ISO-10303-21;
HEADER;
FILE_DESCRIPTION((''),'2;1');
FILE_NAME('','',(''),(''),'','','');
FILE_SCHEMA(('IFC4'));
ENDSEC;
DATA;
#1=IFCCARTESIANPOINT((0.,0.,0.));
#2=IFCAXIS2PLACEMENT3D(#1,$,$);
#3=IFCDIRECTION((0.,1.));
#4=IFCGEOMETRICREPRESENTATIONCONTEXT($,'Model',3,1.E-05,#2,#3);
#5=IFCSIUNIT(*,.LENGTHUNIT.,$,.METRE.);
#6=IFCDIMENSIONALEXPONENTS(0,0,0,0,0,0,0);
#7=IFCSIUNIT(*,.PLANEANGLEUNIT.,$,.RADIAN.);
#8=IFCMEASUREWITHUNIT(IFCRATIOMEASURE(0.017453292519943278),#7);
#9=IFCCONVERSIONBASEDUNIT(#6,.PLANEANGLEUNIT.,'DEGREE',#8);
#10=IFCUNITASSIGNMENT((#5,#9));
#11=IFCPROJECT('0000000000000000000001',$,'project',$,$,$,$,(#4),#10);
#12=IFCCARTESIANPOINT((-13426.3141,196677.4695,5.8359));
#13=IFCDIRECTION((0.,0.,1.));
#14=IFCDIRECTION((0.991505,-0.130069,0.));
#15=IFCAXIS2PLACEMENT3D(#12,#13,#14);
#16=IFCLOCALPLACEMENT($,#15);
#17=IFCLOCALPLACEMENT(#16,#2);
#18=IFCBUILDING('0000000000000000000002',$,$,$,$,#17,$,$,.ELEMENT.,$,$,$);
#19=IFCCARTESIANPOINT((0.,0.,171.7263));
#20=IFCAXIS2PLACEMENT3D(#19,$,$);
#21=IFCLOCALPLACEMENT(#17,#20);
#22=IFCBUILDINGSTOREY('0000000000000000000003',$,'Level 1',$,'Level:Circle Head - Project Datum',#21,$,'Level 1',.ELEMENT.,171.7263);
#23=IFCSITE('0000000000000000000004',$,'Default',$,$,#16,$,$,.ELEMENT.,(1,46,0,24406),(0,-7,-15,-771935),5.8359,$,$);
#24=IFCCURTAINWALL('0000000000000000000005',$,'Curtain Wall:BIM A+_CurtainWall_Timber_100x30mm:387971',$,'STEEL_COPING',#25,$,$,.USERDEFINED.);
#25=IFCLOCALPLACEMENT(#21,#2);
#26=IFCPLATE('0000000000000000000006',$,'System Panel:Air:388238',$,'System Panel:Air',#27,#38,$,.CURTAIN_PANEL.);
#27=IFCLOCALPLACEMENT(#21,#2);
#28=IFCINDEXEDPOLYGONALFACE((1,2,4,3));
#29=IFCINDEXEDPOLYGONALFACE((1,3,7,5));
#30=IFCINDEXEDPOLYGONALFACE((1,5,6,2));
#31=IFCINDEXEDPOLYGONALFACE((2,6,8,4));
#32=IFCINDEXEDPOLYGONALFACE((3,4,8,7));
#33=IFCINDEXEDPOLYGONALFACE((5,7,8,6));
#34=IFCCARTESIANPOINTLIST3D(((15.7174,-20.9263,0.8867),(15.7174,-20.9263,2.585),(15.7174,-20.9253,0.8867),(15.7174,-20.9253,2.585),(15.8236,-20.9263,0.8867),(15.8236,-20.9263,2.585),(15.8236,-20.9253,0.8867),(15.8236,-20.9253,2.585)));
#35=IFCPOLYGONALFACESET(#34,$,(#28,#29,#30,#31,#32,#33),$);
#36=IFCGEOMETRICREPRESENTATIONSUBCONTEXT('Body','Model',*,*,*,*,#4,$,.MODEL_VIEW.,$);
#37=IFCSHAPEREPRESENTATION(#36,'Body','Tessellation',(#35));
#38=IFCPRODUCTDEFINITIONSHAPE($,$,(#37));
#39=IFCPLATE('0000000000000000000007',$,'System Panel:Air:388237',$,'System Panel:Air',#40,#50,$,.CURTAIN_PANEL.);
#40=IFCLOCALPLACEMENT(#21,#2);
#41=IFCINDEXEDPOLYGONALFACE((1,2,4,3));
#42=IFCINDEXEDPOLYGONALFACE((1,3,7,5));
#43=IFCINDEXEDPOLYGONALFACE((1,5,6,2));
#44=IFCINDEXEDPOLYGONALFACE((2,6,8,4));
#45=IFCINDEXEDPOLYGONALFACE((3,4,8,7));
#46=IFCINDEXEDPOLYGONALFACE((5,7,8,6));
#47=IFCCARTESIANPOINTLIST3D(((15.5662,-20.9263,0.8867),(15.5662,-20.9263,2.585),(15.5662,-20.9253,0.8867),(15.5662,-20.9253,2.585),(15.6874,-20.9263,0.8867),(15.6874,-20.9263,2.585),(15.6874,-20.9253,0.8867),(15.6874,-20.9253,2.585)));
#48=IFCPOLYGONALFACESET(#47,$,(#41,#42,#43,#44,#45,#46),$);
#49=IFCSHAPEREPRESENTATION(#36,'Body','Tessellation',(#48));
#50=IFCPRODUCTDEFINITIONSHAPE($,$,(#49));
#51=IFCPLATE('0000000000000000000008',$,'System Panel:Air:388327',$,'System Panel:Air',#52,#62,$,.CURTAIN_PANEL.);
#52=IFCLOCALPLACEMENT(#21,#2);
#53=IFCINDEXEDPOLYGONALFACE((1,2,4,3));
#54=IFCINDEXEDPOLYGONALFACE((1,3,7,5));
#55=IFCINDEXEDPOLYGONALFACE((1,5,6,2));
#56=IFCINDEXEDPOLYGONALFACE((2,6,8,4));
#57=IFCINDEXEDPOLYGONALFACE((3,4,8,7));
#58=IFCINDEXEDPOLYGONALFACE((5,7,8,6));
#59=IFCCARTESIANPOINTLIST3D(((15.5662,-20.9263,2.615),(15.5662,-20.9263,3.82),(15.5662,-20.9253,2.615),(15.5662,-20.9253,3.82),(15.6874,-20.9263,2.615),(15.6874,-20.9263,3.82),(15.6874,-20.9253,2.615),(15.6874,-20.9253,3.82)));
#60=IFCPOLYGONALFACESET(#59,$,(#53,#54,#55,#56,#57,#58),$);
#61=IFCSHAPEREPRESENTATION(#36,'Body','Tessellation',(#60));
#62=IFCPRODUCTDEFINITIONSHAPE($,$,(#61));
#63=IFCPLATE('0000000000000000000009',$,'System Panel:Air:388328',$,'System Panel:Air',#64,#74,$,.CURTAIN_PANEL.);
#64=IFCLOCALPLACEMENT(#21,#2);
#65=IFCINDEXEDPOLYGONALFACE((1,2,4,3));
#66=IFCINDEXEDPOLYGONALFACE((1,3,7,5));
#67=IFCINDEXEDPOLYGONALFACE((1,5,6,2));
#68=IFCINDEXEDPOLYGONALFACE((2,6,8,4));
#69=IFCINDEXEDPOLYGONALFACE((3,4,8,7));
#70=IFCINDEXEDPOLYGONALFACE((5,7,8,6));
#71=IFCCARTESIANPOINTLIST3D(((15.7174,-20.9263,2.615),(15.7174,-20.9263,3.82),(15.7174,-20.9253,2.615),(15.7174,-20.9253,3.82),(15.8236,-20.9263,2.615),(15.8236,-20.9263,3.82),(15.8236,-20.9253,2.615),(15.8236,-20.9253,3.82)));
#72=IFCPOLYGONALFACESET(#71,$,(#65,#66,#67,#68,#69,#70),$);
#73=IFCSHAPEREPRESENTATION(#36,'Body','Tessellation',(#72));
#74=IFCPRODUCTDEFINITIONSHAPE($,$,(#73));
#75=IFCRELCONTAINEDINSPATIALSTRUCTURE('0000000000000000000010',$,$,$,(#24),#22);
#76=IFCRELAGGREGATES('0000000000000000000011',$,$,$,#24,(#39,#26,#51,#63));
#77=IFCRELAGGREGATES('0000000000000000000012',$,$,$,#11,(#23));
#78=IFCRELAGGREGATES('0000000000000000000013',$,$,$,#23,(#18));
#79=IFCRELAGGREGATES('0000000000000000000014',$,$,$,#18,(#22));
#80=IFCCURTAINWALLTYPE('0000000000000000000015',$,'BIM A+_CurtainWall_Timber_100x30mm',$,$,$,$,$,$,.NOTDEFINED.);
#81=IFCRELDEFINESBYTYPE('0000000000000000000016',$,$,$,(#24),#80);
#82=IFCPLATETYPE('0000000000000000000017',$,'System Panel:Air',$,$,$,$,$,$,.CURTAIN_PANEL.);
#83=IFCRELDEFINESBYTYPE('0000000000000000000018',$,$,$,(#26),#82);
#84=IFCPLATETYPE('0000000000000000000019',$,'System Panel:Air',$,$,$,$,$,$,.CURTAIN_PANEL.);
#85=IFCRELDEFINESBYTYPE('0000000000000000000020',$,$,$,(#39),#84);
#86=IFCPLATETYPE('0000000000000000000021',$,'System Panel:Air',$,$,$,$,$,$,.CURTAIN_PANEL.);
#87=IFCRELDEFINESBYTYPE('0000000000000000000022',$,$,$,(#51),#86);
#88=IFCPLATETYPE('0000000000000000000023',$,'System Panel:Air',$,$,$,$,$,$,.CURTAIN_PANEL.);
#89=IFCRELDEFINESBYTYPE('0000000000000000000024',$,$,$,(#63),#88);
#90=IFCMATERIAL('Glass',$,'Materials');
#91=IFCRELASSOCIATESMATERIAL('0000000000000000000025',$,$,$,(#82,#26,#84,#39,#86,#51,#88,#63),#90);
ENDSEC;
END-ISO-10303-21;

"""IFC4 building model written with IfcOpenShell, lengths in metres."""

from ifc_helpers import new_model, entity, si_unit, converted_unit, direction, frame, origin, place, context, subcontext, project, spatial, indexed_curve, outline, extrude, source, transform, mapped, material, type_object, type_shapes, element, aggregate, save


model = new_model("IFC4")

# Units and contexts
model_context = context("Model", 3, precision=1e-05, world=origin(), true_north=direction((0.0, 1.0)))
body_context = subcontext(model_context, "Body", "Model", "MODEL_VIEW")
ifc_project = project(units=[si_unit("LENGTHUNIT", "METRE"), converted_unit("PLANEANGLEUNIT", "DEGREE", entity("IfcRatioMeasure", 0.017453292519943278), si_unit("PLANEANGLEUNIT", "RADIAN"), dimensions=[0, 0, 0, 0, 0, 0, 0])], contexts=[model_context])

# Site, building, storey
site_placement = place(None, frame((-13426.3141, 196677.4695, 5.8359), z_axis=(0.0, 0.0, 1.0), x_axis=(0.991505, -0.130069, 0.0)))
site = spatial("IfcSite", under=ifc_project, at=site_placement, Name="Default", CompositionType="ELEMENT", RefLatitude=(1, 46, 0, 24406), RefLongitude=(0, -7, -15, -771935), RefElevation=5.8359)
building_placement = place(site_placement, origin())
building = spatial("IfcBuilding", under=site, at=building_placement, CompositionType="ELEMENT")
storey_placement = place(building_placement, frame((0.0, 0.0, 171.7263)))
storey = spatial("IfcBuildingStorey", under=building, at=storey_placement, Name="Level 1", ObjectType="Level:Circle Head - Project Datum", LongName="Level 1", CompositionType="ELEMENT", Elevation=171.7263)

# Curtain wall
curtain_wall_type_1 = type_object("IfcCurtainWallType", Name="BIM A+_CurtainWall_Timber_100x30mm", PredefinedType="NOTDEFINED")
curtain_wall_1_placement = place(storey_placement, frame((0.0, 0.0, -171.7263)))
curtain_wall_1 = element("IfcCurtainWall", 1, at=curtain_wall_1_placement, inside=storey, type_object=curtain_wall_type_1, Name="Curtain Wall:BIM A+_CurtainWall_Timber_100x30mm:387971", ObjectType="STEEL_COPING", PredefinedType="USERDEFINED")

# Plates
ifc_material_1 = material(Name="Glass", Category="Materials")
plate_type_1 = type_object("IfcPlateType", Name="System Panel:Air", PredefinedType="CURTAIN_PANEL", material=ifc_material_1)
shared_shape_1 = source(origin(), body_context, "Body", "SweptSolid", [
    extrude(outline(indexed_curve([(-0.0005, -0.0531), (0.0005, -0.0531), (0.0005, 0.0531), (-0.0005, 0.0531), (-0.0005, -0.0531)], self_intersect=False)), frame((0.0, 0.0, 0.0), z_axis=(0.0, 0.0, 1.0), x_axis=(0.0, 1.0, 0.0)), (0.0, 0.0, 1.0), 1.6983),
])
type_shapes(plate_type_1, [shared_shape_1])
plate_1_placement = place(curtain_wall_1_placement, frame((15.7705, -20.9258, 172.613)))
plate_1 = element("IfcPlate", 2, at=plate_1_placement, type_object=plate_type_1, material=ifc_material_1, Name="System Panel:Air:388238", ObjectType="System Panel:Air", PredefinedType="CURTAIN_PANEL", context=body_context, shape_type="MappedRepresentation", body=[
    mapped(shared_shape_1, transform((0.0, 0.0, 0.0), scale=1.0)),
])
plate_type_2 = type_object("IfcPlateType", Name="System Panel:Air", PredefinedType="CURTAIN_PANEL", material=ifc_material_1)
shared_shape_2 = source(origin(), body_context, "Body", "SweptSolid", [
    extrude(outline(indexed_curve([(-0.0005, -0.0606), (0.0005, -0.0606), (0.0005, 0.0606), (-0.0005, 0.0606), (-0.0005, -0.0606)], self_intersect=False)), frame((0.0, 0.0, 0.0), z_axis=(0.0, 0.0, 1.0), x_axis=(0.0, 1.0, 0.0)), (0.0, 0.0, 1.0), 1.6983),
])
type_shapes(plate_type_2, [shared_shape_2])
plate_2_placement = place(curtain_wall_1_placement, frame((15.6268, -20.9258, 172.613)))
plate_2 = element("IfcPlate", 3, at=plate_2_placement, type_object=plate_type_2, material=ifc_material_1, Name="System Panel:Air:388237", ObjectType="System Panel:Air", PredefinedType="CURTAIN_PANEL", context=body_context, shape_type="MappedRepresentation", body=[
    mapped(shared_shape_2, transform((0.0, 0.0, 0.0), scale=1.0)),
])
plate_type_3 = type_object("IfcPlateType", Name="System Panel:Air", PredefinedType="CURTAIN_PANEL", material=ifc_material_1)
shared_shape_3 = source(origin(), body_context, "Body", "SweptSolid", [
    extrude(outline(indexed_curve([(-0.0005, -0.0606), (0.0005, -0.0606), (0.0005, 0.0606), (-0.0005, 0.0606), (-0.0005, -0.0606)], self_intersect=False)), frame((0.0, 0.0, 0.0), z_axis=(0.0, 0.0, 1.0), x_axis=(0.0, 1.0, 0.0)), (0.0, 0.0, 1.0), 1.205),
])
type_shapes(plate_type_3, [shared_shape_3])
plate_3_placement = place(curtain_wall_1_placement, frame((15.6268, -20.9258, 174.3413)))
plate_3 = element("IfcPlate", 4, at=plate_3_placement, type_object=plate_type_3, material=ifc_material_1, Name="System Panel:Air:388327", ObjectType="System Panel:Air", PredefinedType="CURTAIN_PANEL", context=body_context, shape_type="MappedRepresentation", body=[
    mapped(shared_shape_3, transform((0.0, 0.0, 0.0), scale=1.0)),
])
plate_type_4 = type_object("IfcPlateType", Name="System Panel:Air", PredefinedType="CURTAIN_PANEL", material=ifc_material_1)
shared_shape_4 = source(origin(), body_context, "Body", "SweptSolid", [
    extrude(outline(indexed_curve([(-0.0005, -0.0531), (0.0005, -0.0531), (0.0005, 0.0531), (-0.0005, 0.0531), (-0.0005, -0.0531)], self_intersect=False)), frame((0.0, 0.0, 0.0), z_axis=(0.0, 0.0, 1.0), x_axis=(0.0, 1.0, 0.0)), (0.0, 0.0, 1.0), 1.205),
])
type_shapes(plate_type_4, [shared_shape_4])
plate_4_placement = place(curtain_wall_1_placement, frame((15.7705, -20.9258, 174.3413)))
plate_4 = element("IfcPlate", 5, at=plate_4_placement, type_object=plate_type_4, material=ifc_material_1, Name="System Panel:Air:388328", ObjectType="System Panel:Air", PredefinedType="CURTAIN_PANEL", context=body_context, shape_type="MappedRepresentation", body=[
    mapped(shared_shape_4, transform((0.0, 0.0, 0.0), scale=1.0)),
])
aggregate(curtain_wall_1, [plate_2, plate_1, plate_3, plate_4])

save(model, "model.ifc")
